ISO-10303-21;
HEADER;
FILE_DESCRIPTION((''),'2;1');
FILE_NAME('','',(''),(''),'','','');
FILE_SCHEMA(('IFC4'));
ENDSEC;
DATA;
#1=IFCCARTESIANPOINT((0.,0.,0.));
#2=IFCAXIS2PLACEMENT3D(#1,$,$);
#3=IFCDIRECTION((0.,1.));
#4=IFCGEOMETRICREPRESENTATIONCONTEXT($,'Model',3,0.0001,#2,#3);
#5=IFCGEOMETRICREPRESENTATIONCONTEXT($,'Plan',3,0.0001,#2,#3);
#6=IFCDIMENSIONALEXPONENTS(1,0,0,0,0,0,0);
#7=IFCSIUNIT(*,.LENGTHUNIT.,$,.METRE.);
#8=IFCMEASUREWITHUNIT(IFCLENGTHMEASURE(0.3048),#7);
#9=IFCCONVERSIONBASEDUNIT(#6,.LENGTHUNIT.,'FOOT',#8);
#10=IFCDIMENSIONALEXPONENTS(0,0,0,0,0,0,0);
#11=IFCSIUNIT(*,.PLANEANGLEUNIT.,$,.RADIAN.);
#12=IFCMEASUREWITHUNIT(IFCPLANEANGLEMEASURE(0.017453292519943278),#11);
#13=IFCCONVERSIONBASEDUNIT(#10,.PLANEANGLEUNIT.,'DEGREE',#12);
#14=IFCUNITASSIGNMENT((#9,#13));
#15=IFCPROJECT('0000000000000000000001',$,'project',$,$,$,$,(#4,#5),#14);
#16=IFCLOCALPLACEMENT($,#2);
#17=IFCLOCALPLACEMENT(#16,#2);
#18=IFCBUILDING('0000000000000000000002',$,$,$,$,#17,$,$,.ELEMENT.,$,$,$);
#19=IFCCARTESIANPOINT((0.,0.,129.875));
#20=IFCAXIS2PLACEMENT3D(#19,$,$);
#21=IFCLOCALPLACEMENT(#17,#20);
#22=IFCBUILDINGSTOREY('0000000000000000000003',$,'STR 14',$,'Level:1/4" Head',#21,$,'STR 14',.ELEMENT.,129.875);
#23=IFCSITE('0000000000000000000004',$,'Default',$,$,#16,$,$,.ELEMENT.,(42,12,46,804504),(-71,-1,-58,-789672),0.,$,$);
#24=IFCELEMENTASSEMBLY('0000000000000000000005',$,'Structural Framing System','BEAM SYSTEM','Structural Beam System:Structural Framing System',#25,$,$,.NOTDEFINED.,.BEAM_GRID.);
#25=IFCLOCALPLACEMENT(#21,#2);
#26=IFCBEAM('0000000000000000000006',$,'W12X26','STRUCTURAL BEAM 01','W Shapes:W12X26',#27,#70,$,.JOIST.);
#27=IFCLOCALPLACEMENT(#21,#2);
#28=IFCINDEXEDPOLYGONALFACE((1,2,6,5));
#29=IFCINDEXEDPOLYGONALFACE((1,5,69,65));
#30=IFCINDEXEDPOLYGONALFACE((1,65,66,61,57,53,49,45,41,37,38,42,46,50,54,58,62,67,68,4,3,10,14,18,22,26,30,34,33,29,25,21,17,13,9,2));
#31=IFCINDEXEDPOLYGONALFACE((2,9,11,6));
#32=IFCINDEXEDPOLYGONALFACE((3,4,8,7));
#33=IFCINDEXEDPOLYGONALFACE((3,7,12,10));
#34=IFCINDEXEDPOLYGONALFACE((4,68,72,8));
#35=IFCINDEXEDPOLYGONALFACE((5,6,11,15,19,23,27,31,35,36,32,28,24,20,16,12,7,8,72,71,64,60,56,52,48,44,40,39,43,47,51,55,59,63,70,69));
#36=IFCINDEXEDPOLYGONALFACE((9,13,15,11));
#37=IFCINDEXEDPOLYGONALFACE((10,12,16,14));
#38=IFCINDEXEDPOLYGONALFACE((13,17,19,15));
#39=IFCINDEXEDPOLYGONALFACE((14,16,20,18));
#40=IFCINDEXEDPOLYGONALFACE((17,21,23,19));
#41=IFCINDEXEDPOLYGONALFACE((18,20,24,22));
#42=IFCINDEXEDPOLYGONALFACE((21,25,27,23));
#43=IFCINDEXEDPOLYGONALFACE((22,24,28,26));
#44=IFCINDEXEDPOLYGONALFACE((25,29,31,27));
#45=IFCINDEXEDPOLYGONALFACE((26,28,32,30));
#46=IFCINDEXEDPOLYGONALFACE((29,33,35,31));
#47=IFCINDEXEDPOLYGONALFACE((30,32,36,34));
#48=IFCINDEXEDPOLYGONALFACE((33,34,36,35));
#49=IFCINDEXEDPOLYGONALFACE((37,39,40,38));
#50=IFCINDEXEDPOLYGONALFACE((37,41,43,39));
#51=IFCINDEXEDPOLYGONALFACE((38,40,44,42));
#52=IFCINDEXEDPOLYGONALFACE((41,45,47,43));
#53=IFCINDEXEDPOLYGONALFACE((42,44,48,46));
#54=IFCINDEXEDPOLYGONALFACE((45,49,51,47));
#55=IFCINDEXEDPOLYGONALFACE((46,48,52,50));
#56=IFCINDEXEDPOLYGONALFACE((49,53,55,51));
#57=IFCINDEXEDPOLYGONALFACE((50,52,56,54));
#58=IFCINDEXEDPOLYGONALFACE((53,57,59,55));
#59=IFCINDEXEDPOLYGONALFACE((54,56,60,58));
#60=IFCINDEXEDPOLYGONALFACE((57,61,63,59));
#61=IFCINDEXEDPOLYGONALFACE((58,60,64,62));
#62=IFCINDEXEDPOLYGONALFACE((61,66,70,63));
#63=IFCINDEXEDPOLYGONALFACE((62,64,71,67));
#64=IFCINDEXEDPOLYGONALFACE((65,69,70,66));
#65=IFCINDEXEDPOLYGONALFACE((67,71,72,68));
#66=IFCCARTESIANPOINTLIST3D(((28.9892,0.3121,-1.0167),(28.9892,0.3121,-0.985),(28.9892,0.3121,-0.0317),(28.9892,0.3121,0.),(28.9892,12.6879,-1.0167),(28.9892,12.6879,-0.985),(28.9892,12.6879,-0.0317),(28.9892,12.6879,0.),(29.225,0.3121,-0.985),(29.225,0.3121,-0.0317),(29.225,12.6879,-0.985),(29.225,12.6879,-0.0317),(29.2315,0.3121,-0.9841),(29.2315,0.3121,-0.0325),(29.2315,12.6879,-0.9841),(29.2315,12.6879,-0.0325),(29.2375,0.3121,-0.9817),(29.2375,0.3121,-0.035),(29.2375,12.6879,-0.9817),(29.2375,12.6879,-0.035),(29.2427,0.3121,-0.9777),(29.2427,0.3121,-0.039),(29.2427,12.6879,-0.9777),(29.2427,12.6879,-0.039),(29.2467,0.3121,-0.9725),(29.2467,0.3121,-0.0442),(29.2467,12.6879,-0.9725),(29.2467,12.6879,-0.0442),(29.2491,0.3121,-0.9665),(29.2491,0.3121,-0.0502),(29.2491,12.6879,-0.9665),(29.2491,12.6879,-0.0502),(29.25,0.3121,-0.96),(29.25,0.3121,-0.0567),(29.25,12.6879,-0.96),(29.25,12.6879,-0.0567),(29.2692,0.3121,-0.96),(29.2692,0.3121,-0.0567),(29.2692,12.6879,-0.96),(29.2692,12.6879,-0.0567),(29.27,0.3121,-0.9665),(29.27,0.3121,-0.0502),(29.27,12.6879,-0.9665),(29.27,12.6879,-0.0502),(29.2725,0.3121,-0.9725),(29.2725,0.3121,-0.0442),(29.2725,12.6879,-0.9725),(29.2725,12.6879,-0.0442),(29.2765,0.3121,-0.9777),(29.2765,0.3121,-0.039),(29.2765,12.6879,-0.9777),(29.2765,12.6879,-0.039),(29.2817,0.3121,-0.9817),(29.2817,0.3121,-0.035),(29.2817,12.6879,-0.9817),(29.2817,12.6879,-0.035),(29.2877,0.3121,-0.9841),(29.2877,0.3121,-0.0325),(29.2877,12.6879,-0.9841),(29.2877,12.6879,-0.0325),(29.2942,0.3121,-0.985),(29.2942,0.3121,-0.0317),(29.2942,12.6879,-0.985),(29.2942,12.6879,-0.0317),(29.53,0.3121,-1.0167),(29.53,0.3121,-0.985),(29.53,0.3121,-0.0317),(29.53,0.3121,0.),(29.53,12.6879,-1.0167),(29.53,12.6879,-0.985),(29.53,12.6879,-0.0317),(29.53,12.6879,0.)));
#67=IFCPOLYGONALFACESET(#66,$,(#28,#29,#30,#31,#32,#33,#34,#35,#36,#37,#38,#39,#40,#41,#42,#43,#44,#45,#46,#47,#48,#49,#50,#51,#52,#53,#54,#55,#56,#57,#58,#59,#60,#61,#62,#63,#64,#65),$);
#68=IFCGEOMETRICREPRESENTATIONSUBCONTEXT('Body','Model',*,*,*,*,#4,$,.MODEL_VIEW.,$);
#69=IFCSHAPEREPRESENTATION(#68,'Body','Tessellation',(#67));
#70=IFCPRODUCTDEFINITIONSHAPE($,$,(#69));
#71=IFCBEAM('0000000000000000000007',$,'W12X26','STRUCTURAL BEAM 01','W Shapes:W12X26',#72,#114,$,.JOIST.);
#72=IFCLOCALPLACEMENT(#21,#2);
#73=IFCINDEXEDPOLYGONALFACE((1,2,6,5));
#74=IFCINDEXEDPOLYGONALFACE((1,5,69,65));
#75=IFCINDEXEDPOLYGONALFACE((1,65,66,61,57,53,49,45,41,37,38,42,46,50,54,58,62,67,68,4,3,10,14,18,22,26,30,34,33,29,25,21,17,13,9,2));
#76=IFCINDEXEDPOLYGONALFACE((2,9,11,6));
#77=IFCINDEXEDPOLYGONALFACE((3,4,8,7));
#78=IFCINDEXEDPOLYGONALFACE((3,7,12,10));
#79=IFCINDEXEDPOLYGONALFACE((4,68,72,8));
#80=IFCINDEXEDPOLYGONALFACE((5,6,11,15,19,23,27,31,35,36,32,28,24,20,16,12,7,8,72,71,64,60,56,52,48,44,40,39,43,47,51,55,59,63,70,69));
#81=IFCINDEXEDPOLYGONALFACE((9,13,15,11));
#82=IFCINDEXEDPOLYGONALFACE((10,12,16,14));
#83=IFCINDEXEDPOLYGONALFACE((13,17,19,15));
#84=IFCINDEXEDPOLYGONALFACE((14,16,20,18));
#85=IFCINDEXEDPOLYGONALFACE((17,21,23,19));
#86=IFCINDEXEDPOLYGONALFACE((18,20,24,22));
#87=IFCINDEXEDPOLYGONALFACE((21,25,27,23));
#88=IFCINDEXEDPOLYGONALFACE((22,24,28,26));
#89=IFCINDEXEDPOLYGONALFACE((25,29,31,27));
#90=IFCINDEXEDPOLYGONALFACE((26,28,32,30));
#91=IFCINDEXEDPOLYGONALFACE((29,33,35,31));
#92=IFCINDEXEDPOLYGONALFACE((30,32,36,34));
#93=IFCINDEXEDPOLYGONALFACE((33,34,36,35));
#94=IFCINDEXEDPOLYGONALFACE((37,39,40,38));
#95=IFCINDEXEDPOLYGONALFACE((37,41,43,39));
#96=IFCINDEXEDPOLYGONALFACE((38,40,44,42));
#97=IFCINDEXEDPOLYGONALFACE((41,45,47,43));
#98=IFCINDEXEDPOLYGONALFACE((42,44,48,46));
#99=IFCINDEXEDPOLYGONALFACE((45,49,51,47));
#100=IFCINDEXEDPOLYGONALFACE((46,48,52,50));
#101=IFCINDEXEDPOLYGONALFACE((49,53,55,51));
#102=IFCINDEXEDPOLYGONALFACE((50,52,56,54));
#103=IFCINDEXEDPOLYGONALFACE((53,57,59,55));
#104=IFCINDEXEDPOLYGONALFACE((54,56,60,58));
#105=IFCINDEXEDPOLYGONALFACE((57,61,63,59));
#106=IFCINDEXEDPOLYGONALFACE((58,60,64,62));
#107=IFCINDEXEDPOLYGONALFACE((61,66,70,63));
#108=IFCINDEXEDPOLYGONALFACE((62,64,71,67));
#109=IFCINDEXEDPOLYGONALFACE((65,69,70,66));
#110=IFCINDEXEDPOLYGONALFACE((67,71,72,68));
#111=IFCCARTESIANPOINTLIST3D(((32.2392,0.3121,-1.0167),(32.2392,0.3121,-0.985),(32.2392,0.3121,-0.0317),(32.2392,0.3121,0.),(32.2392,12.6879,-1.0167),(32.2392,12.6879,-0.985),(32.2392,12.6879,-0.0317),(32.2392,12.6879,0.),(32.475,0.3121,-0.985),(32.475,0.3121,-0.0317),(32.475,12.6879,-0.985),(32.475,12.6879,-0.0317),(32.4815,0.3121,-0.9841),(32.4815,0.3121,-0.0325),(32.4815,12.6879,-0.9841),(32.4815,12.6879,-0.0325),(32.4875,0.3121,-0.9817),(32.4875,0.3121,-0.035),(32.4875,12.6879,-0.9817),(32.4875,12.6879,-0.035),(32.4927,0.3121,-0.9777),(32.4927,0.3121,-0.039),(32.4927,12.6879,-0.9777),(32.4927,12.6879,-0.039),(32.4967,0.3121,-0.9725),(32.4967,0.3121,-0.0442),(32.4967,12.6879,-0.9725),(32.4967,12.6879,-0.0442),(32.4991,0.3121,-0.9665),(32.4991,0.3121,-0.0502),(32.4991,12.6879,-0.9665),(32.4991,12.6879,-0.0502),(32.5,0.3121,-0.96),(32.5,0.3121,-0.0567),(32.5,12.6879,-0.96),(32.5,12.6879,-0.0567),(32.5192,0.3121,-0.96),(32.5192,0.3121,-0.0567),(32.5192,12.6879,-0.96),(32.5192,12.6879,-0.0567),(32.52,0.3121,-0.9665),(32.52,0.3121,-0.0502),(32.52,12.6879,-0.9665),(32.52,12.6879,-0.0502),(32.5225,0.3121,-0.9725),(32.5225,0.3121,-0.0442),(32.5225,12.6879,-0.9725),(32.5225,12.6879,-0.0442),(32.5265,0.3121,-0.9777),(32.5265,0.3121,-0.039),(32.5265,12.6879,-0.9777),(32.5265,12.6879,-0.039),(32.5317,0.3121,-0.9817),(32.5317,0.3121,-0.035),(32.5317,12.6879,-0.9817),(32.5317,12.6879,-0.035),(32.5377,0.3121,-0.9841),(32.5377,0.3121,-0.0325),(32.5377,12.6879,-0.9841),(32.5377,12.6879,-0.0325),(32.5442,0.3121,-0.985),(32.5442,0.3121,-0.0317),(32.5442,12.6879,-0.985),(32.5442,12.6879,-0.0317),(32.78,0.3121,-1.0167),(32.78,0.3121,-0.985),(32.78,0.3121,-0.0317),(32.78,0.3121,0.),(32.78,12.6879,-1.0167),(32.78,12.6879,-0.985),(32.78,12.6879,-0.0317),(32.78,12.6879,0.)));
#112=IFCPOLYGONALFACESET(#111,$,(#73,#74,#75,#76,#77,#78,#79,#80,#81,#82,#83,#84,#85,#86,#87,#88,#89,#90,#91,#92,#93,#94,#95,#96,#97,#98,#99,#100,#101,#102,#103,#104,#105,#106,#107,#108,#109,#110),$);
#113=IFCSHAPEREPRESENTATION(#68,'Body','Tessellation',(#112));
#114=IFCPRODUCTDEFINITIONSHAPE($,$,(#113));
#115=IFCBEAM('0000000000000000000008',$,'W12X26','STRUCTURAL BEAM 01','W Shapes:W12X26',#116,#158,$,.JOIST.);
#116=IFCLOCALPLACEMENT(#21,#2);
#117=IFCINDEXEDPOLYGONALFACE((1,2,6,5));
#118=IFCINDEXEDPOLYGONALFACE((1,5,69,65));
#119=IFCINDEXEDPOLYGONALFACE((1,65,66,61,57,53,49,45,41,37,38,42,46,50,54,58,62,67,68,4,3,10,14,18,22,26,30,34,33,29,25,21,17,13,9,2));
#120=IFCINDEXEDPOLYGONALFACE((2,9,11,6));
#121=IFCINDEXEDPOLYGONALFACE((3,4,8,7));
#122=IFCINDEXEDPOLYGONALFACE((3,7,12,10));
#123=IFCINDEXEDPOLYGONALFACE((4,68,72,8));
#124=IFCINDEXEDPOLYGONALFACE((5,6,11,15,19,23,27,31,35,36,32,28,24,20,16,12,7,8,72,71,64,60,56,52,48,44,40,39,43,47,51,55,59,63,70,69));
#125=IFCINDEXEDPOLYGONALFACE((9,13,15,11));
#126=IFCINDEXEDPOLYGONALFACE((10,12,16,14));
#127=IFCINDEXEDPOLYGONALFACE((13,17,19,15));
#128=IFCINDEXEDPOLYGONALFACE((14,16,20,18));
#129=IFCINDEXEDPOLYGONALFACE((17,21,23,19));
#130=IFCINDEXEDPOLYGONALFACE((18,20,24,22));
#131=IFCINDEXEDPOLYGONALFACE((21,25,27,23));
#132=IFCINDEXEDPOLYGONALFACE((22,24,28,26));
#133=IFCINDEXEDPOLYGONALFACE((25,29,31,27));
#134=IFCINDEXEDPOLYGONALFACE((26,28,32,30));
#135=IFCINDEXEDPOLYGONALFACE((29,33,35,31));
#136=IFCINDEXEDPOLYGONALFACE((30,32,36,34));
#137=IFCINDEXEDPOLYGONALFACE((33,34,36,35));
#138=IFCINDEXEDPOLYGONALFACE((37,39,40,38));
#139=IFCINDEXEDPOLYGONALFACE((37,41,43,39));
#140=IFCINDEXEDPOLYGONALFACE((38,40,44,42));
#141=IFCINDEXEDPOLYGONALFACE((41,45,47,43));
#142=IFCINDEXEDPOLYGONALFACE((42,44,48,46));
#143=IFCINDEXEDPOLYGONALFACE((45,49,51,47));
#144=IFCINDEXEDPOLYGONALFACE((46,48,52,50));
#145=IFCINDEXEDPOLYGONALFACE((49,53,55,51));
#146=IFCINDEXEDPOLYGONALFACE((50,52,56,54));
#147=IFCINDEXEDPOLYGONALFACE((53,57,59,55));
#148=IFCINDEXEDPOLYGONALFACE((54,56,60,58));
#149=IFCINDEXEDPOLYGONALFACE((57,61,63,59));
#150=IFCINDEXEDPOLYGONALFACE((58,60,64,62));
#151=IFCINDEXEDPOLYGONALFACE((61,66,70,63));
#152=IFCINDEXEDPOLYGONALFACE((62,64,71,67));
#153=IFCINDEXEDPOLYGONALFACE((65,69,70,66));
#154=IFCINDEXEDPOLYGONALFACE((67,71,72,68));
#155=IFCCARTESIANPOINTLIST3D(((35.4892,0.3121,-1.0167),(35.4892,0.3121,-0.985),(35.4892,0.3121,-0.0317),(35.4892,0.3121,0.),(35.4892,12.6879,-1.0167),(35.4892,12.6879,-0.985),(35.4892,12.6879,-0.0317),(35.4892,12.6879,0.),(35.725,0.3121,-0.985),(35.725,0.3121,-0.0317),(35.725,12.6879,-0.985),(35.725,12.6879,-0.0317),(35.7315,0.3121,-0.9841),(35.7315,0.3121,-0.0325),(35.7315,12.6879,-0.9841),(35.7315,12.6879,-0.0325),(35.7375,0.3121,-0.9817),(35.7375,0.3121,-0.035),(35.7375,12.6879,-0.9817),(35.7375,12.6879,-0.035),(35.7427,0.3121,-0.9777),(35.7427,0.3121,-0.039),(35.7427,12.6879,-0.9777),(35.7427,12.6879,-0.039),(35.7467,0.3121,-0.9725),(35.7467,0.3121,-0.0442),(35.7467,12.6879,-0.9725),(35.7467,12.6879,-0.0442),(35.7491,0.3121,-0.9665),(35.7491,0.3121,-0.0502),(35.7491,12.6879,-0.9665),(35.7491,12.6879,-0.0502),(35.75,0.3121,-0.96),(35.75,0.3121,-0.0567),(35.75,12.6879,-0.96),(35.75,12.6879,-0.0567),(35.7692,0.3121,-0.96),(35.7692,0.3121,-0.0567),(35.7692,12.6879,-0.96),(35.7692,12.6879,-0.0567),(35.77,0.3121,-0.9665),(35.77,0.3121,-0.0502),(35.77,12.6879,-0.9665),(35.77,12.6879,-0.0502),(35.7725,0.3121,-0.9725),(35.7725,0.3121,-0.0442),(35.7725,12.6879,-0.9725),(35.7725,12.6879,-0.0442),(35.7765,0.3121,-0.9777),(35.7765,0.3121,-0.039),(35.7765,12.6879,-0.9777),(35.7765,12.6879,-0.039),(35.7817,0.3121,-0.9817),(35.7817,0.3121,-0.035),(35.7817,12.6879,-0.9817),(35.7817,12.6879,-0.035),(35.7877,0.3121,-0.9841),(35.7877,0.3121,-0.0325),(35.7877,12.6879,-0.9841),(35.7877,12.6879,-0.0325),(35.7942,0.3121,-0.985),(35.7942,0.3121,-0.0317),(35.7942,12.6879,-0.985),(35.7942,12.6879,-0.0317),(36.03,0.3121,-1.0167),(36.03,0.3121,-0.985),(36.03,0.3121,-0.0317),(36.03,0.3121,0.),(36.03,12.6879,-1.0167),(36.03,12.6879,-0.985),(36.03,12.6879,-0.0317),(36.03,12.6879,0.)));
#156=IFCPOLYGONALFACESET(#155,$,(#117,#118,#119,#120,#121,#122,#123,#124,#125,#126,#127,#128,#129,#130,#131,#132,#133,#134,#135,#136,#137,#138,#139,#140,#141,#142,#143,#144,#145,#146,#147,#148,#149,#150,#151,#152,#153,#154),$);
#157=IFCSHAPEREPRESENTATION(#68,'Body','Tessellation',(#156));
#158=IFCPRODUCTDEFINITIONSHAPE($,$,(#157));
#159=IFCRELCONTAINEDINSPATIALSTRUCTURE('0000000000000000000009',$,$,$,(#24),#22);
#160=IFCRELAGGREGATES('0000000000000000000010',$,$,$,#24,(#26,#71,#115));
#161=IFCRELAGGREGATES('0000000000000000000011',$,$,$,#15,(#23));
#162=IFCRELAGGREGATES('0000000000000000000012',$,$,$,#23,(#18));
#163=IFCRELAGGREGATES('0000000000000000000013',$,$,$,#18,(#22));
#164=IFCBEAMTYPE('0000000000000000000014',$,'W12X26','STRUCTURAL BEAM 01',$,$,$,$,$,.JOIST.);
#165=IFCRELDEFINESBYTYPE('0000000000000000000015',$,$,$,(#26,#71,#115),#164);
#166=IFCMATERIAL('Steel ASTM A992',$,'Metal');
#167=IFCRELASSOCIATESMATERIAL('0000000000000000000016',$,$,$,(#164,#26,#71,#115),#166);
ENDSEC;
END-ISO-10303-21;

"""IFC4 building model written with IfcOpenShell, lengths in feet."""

from ifc_helpers import new_model, entity, si_unit, converted_unit, direction, frame, origin, place, context, subcontext, project, spatial, line, arc, indexed_curve, outline, extrude, source, transform, mapped, material, type_object, type_shapes, element, aggregate, save


model = new_model("IFC4")

# Units and contexts
model_context = context("Model", 3, precision=0.0001, world=origin(), true_north=direction((0.0, 1.0)))
plan_context = context("Plan", 3, precision=0.0001, world=origin(), true_north=direction((0.0, 1.0)))
body_context = subcontext(model_context, "Body", "Model", "MODEL_VIEW")
ifc_project = project(units=[converted_unit("LENGTHUNIT", "FOOT", entity("IfcLengthMeasure", 0.3048), si_unit("LENGTHUNIT", "METRE"), dimensions=[1, 0, 0, 0, 0, 0, 0]), converted_unit("PLANEANGLEUNIT", "DEGREE", entity("IfcPlaneAngleMeasure", 0.017453292519943278), si_unit("PLANEANGLEUNIT", "RADIAN"), dimensions=[0, 0, 0, 0, 0, 0, 0])], contexts=[model_context, plan_context])

# Site, building, storey
site_placement = place(None, origin())
site = spatial("IfcSite", under=ifc_project, at=site_placement, Name="Default", CompositionType="ELEMENT", RefLatitude=(42, 12, 46, 804504), RefLongitude=(-71, -1, -58, -789672), RefElevation=0.0)
building_placement = place(site_placement, origin())
building = spatial("IfcBuilding", under=site, at=building_placement, CompositionType="ELEMENT")
storey_placement = place(building_placement, frame((0.0, 0.0, 129.875)))
storey = spatial("IfcBuildingStorey", under=building, at=storey_placement, Name="STR 14", ObjectType="Level:1/4\" Head", LongName="STR 14", CompositionType="ELEMENT", Elevation=129.875)

# Shared definitions
ifc_material = material(Name="Steel ASTM A992", Category="Metal")

# Element assembly, beams
beam_type_1 = type_object("IfcBeamType", Name="W12X26", Description="STRUCTURAL BEAM 01", PredefinedType="JOIST", material=ifc_material)
shared_shape_1 = source(origin(), body_context, "Body", "SweptSolid", [
    extrude(outline(indexed_curve([(-0.2704, -0.4767), (-0.2704, -0.5083), (0.2704, -0.5083), (0.2704, -0.4767), (0.0346, -0.4767), (0.0169, -0.4693), (0.0096, -0.4517), (0.0096, 0.4517), (0.0169, 0.4693), (0.0346, 0.4767), (0.2704, 0.4767), (0.2704, 0.5083), (-0.2704, 0.5083), (-0.2704, 0.4767), (-0.0346, 0.4767), (-0.0169, 0.4693), (-0.0096, 0.4517), (-0.0096, -0.4517), (-0.0169, -0.4693), (-0.0346, -0.4767)], segments=[line(1, 2, 3, 4, 5), arc(5, 6, 7), line(7, 8), arc(8, 9, 10), line(10, 11, 12, 13, 14, 15), arc(15, 16, 17), line(17, 18), arc(18, 19, 20), line(20, 1)], self_intersect=False)), frame((-6.1879, 0.0, 0.0), z_axis=(-1.0, 0.0, 0.0), x_axis=(0.0, -1.0, 0.0)), (0.0, 0.0, -1.0), 12.3758),
])
type_shapes(beam_type_1, [shared_shape_1])
assembly_1_placement = place(storey_placement, origin())
assembly_1 = element("IfcElementAssembly", 1, at=assembly_1_placement, inside=storey, Name="Structural Framing System", Description="BEAM SYSTEM", ObjectType="Structural Beam System:Structural Framing System", AssemblyPlace="NOTDEFINED", PredefinedType="BEAM_GRID")
beam_1_placement = place(assembly_1_placement, frame((29.2596, 6.5, -0.5083), z_axis=(0.0, 0.0, 1.0), x_axis=(0.0, 1.0, 0.0)))
beam_1 = element("IfcBeam", 2, at=beam_1_placement, type_object=beam_type_1, material=ifc_material, Name="W12X26", Description="STRUCTURAL BEAM 01", ObjectType="W Shapes:W12X26", PredefinedType="JOIST", context=body_context, shape_type="MappedRepresentation", body=[
    mapped(shared_shape_1, transform((0.0, 0.0, 0.0), scale=1.0)),
])
beam_2_placement = place(assembly_1_placement, frame((32.5096, 6.5, -0.5083), z_axis=(0.0, 0.0, 1.0), x_axis=(0.0, 1.0, 0.0)))
beam_2 = element("IfcBeam", 3, at=beam_2_placement, type_object=beam_type_1, material=ifc_material, Name="W12X26", Description="STRUCTURAL BEAM 01", ObjectType="W Shapes:W12X26", PredefinedType="JOIST", context=body_context, shape_type="MappedRepresentation", body=[
    mapped(shared_shape_1, transform((0.0, 0.0, 0.0), scale=1.0)),
])
beam_3_placement = place(assembly_1_placement, frame((35.7596, 6.5, -0.5083), z_axis=(0.0, 0.0, 1.0), x_axis=(0.0, 1.0, 0.0)))
beam_3 = element("IfcBeam", 4, at=beam_3_placement, type_object=beam_type_1, material=ifc_material, Name="W12X26", Description="STRUCTURAL BEAM 01", ObjectType="W Shapes:W12X26", PredefinedType="JOIST", context=body_context, shape_type="MappedRepresentation", body=[
    mapped(shared_shape_1, transform((0.0, 0.0, 0.0), scale=1.0)),
])
aggregate(assembly_1, [beam_1, beam_2, beam_3])

save(model, "model.ifc")
